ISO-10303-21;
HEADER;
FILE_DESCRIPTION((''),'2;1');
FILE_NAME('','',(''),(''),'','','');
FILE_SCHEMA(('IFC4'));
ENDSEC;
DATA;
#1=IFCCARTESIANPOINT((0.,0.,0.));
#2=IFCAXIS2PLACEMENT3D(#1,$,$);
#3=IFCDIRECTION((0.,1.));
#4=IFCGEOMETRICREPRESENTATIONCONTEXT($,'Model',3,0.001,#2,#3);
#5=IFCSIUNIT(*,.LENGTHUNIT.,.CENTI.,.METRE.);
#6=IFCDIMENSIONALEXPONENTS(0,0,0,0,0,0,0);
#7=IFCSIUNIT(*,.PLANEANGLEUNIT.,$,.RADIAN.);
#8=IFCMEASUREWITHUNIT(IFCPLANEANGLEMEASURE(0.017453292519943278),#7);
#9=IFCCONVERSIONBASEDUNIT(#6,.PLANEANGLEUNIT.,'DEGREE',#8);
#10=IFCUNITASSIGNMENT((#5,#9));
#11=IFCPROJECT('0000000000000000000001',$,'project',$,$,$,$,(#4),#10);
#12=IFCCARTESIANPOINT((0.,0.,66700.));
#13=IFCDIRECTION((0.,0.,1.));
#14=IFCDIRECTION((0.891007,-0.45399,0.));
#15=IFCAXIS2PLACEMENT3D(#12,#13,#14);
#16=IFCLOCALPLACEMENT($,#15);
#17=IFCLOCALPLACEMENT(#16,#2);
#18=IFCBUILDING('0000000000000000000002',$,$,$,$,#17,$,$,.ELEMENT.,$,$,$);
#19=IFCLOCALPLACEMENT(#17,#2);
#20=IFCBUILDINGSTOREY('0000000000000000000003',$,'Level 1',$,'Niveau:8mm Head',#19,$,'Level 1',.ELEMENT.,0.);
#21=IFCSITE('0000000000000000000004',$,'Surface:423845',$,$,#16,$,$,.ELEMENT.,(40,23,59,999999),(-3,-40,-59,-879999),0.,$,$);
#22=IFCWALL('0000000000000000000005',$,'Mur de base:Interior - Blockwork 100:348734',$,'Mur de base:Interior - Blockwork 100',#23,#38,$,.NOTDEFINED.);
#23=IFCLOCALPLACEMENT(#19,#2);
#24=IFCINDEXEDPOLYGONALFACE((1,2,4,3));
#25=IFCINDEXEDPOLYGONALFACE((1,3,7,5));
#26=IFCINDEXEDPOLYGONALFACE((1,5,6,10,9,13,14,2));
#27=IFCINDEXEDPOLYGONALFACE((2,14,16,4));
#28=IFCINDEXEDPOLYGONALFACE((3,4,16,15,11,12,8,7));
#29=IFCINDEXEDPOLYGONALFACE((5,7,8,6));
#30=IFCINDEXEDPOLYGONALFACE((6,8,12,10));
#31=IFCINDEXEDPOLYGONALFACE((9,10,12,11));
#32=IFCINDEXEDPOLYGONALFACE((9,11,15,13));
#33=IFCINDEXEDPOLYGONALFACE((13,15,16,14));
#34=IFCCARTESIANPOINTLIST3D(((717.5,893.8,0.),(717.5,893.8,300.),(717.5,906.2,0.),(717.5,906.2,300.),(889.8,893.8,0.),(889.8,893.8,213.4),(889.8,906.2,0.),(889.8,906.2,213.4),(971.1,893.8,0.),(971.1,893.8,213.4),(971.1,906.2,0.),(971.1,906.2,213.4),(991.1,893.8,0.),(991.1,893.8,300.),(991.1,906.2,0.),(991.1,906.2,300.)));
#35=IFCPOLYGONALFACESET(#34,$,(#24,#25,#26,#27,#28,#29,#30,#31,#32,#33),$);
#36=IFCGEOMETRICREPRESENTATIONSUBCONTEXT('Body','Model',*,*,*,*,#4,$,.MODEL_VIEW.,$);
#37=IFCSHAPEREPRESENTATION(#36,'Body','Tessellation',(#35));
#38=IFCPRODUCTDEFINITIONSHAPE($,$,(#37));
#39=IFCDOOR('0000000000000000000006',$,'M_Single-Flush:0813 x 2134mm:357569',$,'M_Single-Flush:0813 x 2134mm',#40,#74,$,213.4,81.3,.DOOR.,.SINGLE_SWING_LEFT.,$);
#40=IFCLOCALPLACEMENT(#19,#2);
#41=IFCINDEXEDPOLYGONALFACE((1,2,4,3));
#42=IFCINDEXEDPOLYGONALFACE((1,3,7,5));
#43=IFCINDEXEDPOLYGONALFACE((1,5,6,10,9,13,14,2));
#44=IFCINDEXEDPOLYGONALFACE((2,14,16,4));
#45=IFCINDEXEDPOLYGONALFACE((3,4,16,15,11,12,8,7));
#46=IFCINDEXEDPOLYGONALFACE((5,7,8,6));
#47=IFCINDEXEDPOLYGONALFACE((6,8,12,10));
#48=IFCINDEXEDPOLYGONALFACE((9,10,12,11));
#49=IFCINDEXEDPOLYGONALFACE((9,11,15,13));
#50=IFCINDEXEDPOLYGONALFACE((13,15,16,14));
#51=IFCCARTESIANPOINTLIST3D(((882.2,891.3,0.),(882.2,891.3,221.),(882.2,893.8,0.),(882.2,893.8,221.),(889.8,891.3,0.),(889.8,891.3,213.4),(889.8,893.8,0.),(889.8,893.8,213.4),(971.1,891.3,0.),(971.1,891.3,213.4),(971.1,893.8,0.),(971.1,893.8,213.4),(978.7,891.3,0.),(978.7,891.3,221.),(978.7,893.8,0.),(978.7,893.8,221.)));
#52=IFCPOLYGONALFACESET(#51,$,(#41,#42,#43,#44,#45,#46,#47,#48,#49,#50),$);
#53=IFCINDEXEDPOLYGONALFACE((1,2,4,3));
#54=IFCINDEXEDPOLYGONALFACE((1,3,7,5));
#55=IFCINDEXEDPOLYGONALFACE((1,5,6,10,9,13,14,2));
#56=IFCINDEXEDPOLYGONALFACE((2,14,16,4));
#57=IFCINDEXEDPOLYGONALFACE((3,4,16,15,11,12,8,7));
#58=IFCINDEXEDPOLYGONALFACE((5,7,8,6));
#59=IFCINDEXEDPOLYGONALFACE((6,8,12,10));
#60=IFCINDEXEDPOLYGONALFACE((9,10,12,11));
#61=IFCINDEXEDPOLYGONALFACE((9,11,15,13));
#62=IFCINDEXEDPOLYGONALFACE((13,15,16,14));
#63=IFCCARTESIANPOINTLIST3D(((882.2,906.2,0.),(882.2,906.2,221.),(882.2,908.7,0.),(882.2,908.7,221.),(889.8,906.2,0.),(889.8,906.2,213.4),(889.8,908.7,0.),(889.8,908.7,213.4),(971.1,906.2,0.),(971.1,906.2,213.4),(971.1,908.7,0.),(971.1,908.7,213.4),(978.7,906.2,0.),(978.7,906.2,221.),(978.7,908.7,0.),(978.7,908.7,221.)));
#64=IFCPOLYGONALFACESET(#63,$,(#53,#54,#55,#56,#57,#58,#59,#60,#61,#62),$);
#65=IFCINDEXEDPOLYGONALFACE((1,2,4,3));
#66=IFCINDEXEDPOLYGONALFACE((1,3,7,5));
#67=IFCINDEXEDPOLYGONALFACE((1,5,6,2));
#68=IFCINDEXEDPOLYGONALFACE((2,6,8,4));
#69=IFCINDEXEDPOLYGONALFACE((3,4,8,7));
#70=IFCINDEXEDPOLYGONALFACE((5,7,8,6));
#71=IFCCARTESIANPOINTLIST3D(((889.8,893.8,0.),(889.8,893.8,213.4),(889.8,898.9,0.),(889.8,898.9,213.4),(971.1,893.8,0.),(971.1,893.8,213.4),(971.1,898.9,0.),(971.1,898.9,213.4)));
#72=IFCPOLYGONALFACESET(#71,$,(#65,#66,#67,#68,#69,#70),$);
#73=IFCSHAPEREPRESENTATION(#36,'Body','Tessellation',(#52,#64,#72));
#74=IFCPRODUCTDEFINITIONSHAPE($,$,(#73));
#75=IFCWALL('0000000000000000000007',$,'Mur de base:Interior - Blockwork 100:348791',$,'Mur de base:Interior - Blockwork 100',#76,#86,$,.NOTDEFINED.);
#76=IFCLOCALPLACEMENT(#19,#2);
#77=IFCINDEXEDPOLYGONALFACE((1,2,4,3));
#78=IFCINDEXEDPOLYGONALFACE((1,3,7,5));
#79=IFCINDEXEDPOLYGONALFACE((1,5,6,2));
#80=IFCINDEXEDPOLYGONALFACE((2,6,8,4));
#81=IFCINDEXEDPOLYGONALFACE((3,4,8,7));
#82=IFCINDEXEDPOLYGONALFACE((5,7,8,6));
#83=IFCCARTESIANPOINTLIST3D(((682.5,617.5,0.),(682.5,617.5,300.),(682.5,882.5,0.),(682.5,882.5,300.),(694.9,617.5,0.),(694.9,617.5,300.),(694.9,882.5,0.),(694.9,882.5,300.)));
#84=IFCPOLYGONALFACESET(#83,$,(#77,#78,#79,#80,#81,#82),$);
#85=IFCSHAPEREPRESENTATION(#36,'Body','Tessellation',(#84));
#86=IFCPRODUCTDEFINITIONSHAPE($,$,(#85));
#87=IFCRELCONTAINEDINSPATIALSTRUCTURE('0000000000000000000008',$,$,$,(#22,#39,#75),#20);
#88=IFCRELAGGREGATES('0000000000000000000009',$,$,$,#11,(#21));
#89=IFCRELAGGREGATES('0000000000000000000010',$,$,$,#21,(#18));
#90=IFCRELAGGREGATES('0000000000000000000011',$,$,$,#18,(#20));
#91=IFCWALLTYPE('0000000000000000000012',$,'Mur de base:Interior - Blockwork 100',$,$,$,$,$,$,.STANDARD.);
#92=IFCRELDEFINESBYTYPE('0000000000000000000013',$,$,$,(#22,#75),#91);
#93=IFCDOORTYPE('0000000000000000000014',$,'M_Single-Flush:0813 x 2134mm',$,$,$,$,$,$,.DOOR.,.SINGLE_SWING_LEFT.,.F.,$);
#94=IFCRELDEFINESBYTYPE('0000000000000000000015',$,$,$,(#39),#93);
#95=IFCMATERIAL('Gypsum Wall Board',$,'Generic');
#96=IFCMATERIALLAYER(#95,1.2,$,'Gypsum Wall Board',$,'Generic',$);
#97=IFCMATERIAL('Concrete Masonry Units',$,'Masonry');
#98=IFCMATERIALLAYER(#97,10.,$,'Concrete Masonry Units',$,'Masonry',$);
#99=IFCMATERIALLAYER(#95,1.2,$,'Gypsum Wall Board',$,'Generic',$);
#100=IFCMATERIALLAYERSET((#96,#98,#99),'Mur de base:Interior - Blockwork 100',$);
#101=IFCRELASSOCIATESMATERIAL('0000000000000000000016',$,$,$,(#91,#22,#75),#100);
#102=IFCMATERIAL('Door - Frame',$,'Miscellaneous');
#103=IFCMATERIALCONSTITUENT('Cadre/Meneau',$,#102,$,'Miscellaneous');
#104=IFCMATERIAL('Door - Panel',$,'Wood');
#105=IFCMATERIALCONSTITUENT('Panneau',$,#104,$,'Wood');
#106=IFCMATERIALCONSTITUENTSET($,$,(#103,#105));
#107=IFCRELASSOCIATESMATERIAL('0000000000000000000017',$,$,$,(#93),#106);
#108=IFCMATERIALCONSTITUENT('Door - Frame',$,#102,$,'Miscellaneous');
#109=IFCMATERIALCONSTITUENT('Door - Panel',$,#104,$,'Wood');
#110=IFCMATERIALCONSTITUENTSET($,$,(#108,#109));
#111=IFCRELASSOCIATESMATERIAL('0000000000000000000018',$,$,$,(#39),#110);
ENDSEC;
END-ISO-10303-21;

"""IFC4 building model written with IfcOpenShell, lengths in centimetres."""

from ifc_helpers import new_model, entity, si_unit, converted_unit, direction, frame, frame_2d, origin, place, context, subcontext, project, spatial, polyline, rectangle, outline, extrude, source, transform, mapped, material, layer, layer_set, layer_usage, constituent, constituent_set, type_object, type_shapes, element, fill, save


model = new_model("IFC4")

# Units and contexts
model_context = context("Model", 3, precision=0.001, world=origin(), true_north=direction((0.0, 1.0)))
body_context = subcontext(model_context, "Body", "Model", "MODEL_VIEW")
ifc_project = project(units=[si_unit("LENGTHUNIT", "METRE", prefix="CENTI"), converted_unit("PLANEANGLEUNIT", "DEGREE", entity("IfcPlaneAngleMeasure", 0.017453292519943278), si_unit("PLANEANGLEUNIT", "RADIAN"), dimensions=[0, 0, 0, 0, 0, 0, 0])], contexts=[model_context])

# Site, building, storey
site_placement = place(None, frame((0.0, 0.0, 66700.0), z_axis=(0.0, 0.0, 1.0), x_axis=(0.891007, -0.45399, 0.0)))
site = spatial("IfcSite", under=ifc_project, at=site_placement, Name="Surface:423845", CompositionType="ELEMENT", RefLatitude=(40, 23, 59, 999999), RefLongitude=(-3, -40, -59, -879999), RefElevation=0.0)
building_placement = place(site_placement, origin())
building = spatial("IfcBuilding", under=site, at=building_placement, CompositionType="ELEMENT")
storey_placement = place(building_placement, origin())
storey = spatial("IfcBuildingStorey", under=building, at=storey_placement, Name="Level 1", ObjectType="Niveau:8mm Head", LongName="Level 1", CompositionType="ELEMENT", Elevation=0.0)

# Wall, opening, door
ifc_material_1 = material(Name="Gypsum Wall Board", Category="Generic")
ifc_layer_1 = layer(ifc_material_1, 1.2, Name="Gypsum Wall Board", Category="Generic")
ifc_material_2 = material(Name="Concrete Masonry Units", Category="Masonry")
ifc_layer_2 = layer(ifc_material_2, 10.0, Name="Concrete Masonry Units", Category="Masonry")
ifc_layer_3 = layer(ifc_material_1, 1.2, Name="Gypsum Wall Board", Category="Generic")
ifc_layer_set = layer_set([ifc_layer_1, ifc_layer_2, ifc_layer_3], Name="Mur de base:Interior - Blockwork 100")
ifc_layer_usage_1 = layer_usage(ifc_layer_set, "AXIS2", "NEGATIVE", 6.2)
wall_type = type_object("IfcWallType", Name="Mur de base:Interior - Blockwork 100", PredefinedType="STANDARD", material=ifc_layer_set)
wall_1_placement = place(storey_placement, frame((991.1, 900.0, 0.0), z_axis=(0.0, 0.0, 1.0), x_axis=(-1.0, 0.0, 0.0)))
wall_1 = element("IfcWall", 1, at=wall_1_placement, inside=storey, type_object=wall_type, material=ifc_layer_usage_1, Name="Mur de base:Interior - Blockwork 100:348734", ObjectType="Mur de base:Interior - Blockwork 100", PredefinedType="NOTDEFINED", context=body_context, shape_type="SweptSolid", body=[
    extrude(rectangle(XDim=273.6, YDim=12.4, at=frame_2d((136.8, 0.0), x_axis=(1.0, 0.0))), origin(), (0.0, 0.0, 1.0), 300.0),
])
opening_placement = place(wall_1_placement, frame((20.0, -6.2, 0.0)))
opening = element("IfcOpeningElement", 2, at=opening_placement, cuts=wall_1, PredefinedType="OPENING", context=body_context, shape_type="SweptSolid", body=[
    extrude(rectangle(XDim=81.3, YDim=213.4, at=frame_2d((106.7, 40.65), x_axis=(0.0, -1.0))), frame((0.0, 0.0, 0.0), z_axis=(0.0, 1.0, 0.0), x_axis=(0.0, 0.0, 1.0)), (0.0, 0.0, 1.0), 12.4),
])
ifc_material_3 = material(Name="Door - Frame", Category="Miscellaneous")
ifc_constituent_1 = constituent(ifc_material_3, Name="Door - Frame", Category="Miscellaneous")
ifc_material_4 = material(Name="Door - Panel", Category="Wood")
ifc_constituent_2 = constituent(ifc_material_4, Name="Door - Panel", Category="Wood")
ifc_constituent_set_1 = constituent_set(constituents=[ifc_constituent_1, ifc_constituent_2])
ifc_constituent_3 = constituent(ifc_material_3, Name="Cadre/Meneau", Category="Miscellaneous")
ifc_constituent_4 = constituent(ifc_material_4, Name="Panneau", Category="Wood")
ifc_constituent_set_2 = constituent_set(constituents=[ifc_constituent_3, ifc_constituent_4])
door_type = type_object("IfcDoorType", Name="M_Single-Flush:0813 x 2134mm", OperationType="SINGLE_SWING_LEFT", ParameterTakesPrecedence=False, PredefinedType="DOOR", material=ifc_constituent_set_2)
shared_shape_1 = source(origin(), body_context, "Body", "SweptSolid", [
    extrude(outline(polyline([(-48.25, -112.4), (48.25, -112.4), (48.25, 108.6), (40.65, 108.6), (40.65, -104.8), (-40.65, -104.8), (-40.65, 108.6), (-48.25, 108.6), (-48.25, -112.4)])), frame((40.65, 14.9, 108.6), z_axis=(0.0, -1.0, 0.0), x_axis=(-1.0, 0.0, 0.0)), (0.0, 0.0, 1.0), 2.5),
    extrude(outline(polyline([(-112.4, -48.25), (108.6, -48.25), (108.6, -40.65), (-104.8, -40.65), (-104.8, 40.65), (108.6, 40.65), (108.6, 48.25), (-112.4, 48.25), (-112.4, -48.25)])), frame((40.65, 0.0, 108.6), z_axis=(0.0, -1.0, 0.0), x_axis=(0.0, 0.0, -1.0)), (0.0, 0.0, 1.0), 2.5),
    extrude(rectangle(XDim=81.3, YDim=5.1, at=frame_2d((0.0, 0.0), x_axis=(1.0, 0.0))), frame((40.65, 9.85, 0.0)), (0.0, 0.0, 1.0), 213.4),
])
type_shapes(door_type, [shared_shape_1])
door_placement = place(opening_placement, origin())
door = element("IfcDoor", 3, at=door_placement, inside=storey, type_object=door_type, material=ifc_constituent_set_1, Name="M_Single-Flush:0813 x 2134mm:357569", ObjectType="M_Single-Flush:0813 x 2134mm", OperationType="SINGLE_SWING_LEFT", OverallHeight=213.4, OverallWidth=81.3, PredefinedType="DOOR", context=body_context, shape_type="MappedRepresentation", body=[
    mapped(shared_shape_1, transform((0.0, 0.0, 0.0), scale=1.0)),
])
fill(opening, door)

# Wall
ifc_layer_usage_2 = layer_usage(ifc_layer_set, "AXIS2", "NEGATIVE", 6.2)
wall_2_placement = place(storey_placement, frame((688.7, 882.5, 0.0), z_axis=(0.0, 0.0, 1.0), x_axis=(0.0, -1.0, 0.0)))
element("IfcWall", 4, at=wall_2_placement, inside=storey, type_object=wall_type, material=ifc_layer_usage_2, Name="Mur de base:Interior - Blockwork 100:348791", ObjectType="Mur de base:Interior - Blockwork 100", PredefinedType="NOTDEFINED", context=body_context, shape_type="SweptSolid", body=[
    extrude(rectangle(XDim=265.0, YDim=12.4, at=frame_2d((132.5, 0.0), x_axis=(-1.0, 0.0))), origin(), (0.0, 0.0, 1.0), 300.0),
])

save(model, "model.ifc")
